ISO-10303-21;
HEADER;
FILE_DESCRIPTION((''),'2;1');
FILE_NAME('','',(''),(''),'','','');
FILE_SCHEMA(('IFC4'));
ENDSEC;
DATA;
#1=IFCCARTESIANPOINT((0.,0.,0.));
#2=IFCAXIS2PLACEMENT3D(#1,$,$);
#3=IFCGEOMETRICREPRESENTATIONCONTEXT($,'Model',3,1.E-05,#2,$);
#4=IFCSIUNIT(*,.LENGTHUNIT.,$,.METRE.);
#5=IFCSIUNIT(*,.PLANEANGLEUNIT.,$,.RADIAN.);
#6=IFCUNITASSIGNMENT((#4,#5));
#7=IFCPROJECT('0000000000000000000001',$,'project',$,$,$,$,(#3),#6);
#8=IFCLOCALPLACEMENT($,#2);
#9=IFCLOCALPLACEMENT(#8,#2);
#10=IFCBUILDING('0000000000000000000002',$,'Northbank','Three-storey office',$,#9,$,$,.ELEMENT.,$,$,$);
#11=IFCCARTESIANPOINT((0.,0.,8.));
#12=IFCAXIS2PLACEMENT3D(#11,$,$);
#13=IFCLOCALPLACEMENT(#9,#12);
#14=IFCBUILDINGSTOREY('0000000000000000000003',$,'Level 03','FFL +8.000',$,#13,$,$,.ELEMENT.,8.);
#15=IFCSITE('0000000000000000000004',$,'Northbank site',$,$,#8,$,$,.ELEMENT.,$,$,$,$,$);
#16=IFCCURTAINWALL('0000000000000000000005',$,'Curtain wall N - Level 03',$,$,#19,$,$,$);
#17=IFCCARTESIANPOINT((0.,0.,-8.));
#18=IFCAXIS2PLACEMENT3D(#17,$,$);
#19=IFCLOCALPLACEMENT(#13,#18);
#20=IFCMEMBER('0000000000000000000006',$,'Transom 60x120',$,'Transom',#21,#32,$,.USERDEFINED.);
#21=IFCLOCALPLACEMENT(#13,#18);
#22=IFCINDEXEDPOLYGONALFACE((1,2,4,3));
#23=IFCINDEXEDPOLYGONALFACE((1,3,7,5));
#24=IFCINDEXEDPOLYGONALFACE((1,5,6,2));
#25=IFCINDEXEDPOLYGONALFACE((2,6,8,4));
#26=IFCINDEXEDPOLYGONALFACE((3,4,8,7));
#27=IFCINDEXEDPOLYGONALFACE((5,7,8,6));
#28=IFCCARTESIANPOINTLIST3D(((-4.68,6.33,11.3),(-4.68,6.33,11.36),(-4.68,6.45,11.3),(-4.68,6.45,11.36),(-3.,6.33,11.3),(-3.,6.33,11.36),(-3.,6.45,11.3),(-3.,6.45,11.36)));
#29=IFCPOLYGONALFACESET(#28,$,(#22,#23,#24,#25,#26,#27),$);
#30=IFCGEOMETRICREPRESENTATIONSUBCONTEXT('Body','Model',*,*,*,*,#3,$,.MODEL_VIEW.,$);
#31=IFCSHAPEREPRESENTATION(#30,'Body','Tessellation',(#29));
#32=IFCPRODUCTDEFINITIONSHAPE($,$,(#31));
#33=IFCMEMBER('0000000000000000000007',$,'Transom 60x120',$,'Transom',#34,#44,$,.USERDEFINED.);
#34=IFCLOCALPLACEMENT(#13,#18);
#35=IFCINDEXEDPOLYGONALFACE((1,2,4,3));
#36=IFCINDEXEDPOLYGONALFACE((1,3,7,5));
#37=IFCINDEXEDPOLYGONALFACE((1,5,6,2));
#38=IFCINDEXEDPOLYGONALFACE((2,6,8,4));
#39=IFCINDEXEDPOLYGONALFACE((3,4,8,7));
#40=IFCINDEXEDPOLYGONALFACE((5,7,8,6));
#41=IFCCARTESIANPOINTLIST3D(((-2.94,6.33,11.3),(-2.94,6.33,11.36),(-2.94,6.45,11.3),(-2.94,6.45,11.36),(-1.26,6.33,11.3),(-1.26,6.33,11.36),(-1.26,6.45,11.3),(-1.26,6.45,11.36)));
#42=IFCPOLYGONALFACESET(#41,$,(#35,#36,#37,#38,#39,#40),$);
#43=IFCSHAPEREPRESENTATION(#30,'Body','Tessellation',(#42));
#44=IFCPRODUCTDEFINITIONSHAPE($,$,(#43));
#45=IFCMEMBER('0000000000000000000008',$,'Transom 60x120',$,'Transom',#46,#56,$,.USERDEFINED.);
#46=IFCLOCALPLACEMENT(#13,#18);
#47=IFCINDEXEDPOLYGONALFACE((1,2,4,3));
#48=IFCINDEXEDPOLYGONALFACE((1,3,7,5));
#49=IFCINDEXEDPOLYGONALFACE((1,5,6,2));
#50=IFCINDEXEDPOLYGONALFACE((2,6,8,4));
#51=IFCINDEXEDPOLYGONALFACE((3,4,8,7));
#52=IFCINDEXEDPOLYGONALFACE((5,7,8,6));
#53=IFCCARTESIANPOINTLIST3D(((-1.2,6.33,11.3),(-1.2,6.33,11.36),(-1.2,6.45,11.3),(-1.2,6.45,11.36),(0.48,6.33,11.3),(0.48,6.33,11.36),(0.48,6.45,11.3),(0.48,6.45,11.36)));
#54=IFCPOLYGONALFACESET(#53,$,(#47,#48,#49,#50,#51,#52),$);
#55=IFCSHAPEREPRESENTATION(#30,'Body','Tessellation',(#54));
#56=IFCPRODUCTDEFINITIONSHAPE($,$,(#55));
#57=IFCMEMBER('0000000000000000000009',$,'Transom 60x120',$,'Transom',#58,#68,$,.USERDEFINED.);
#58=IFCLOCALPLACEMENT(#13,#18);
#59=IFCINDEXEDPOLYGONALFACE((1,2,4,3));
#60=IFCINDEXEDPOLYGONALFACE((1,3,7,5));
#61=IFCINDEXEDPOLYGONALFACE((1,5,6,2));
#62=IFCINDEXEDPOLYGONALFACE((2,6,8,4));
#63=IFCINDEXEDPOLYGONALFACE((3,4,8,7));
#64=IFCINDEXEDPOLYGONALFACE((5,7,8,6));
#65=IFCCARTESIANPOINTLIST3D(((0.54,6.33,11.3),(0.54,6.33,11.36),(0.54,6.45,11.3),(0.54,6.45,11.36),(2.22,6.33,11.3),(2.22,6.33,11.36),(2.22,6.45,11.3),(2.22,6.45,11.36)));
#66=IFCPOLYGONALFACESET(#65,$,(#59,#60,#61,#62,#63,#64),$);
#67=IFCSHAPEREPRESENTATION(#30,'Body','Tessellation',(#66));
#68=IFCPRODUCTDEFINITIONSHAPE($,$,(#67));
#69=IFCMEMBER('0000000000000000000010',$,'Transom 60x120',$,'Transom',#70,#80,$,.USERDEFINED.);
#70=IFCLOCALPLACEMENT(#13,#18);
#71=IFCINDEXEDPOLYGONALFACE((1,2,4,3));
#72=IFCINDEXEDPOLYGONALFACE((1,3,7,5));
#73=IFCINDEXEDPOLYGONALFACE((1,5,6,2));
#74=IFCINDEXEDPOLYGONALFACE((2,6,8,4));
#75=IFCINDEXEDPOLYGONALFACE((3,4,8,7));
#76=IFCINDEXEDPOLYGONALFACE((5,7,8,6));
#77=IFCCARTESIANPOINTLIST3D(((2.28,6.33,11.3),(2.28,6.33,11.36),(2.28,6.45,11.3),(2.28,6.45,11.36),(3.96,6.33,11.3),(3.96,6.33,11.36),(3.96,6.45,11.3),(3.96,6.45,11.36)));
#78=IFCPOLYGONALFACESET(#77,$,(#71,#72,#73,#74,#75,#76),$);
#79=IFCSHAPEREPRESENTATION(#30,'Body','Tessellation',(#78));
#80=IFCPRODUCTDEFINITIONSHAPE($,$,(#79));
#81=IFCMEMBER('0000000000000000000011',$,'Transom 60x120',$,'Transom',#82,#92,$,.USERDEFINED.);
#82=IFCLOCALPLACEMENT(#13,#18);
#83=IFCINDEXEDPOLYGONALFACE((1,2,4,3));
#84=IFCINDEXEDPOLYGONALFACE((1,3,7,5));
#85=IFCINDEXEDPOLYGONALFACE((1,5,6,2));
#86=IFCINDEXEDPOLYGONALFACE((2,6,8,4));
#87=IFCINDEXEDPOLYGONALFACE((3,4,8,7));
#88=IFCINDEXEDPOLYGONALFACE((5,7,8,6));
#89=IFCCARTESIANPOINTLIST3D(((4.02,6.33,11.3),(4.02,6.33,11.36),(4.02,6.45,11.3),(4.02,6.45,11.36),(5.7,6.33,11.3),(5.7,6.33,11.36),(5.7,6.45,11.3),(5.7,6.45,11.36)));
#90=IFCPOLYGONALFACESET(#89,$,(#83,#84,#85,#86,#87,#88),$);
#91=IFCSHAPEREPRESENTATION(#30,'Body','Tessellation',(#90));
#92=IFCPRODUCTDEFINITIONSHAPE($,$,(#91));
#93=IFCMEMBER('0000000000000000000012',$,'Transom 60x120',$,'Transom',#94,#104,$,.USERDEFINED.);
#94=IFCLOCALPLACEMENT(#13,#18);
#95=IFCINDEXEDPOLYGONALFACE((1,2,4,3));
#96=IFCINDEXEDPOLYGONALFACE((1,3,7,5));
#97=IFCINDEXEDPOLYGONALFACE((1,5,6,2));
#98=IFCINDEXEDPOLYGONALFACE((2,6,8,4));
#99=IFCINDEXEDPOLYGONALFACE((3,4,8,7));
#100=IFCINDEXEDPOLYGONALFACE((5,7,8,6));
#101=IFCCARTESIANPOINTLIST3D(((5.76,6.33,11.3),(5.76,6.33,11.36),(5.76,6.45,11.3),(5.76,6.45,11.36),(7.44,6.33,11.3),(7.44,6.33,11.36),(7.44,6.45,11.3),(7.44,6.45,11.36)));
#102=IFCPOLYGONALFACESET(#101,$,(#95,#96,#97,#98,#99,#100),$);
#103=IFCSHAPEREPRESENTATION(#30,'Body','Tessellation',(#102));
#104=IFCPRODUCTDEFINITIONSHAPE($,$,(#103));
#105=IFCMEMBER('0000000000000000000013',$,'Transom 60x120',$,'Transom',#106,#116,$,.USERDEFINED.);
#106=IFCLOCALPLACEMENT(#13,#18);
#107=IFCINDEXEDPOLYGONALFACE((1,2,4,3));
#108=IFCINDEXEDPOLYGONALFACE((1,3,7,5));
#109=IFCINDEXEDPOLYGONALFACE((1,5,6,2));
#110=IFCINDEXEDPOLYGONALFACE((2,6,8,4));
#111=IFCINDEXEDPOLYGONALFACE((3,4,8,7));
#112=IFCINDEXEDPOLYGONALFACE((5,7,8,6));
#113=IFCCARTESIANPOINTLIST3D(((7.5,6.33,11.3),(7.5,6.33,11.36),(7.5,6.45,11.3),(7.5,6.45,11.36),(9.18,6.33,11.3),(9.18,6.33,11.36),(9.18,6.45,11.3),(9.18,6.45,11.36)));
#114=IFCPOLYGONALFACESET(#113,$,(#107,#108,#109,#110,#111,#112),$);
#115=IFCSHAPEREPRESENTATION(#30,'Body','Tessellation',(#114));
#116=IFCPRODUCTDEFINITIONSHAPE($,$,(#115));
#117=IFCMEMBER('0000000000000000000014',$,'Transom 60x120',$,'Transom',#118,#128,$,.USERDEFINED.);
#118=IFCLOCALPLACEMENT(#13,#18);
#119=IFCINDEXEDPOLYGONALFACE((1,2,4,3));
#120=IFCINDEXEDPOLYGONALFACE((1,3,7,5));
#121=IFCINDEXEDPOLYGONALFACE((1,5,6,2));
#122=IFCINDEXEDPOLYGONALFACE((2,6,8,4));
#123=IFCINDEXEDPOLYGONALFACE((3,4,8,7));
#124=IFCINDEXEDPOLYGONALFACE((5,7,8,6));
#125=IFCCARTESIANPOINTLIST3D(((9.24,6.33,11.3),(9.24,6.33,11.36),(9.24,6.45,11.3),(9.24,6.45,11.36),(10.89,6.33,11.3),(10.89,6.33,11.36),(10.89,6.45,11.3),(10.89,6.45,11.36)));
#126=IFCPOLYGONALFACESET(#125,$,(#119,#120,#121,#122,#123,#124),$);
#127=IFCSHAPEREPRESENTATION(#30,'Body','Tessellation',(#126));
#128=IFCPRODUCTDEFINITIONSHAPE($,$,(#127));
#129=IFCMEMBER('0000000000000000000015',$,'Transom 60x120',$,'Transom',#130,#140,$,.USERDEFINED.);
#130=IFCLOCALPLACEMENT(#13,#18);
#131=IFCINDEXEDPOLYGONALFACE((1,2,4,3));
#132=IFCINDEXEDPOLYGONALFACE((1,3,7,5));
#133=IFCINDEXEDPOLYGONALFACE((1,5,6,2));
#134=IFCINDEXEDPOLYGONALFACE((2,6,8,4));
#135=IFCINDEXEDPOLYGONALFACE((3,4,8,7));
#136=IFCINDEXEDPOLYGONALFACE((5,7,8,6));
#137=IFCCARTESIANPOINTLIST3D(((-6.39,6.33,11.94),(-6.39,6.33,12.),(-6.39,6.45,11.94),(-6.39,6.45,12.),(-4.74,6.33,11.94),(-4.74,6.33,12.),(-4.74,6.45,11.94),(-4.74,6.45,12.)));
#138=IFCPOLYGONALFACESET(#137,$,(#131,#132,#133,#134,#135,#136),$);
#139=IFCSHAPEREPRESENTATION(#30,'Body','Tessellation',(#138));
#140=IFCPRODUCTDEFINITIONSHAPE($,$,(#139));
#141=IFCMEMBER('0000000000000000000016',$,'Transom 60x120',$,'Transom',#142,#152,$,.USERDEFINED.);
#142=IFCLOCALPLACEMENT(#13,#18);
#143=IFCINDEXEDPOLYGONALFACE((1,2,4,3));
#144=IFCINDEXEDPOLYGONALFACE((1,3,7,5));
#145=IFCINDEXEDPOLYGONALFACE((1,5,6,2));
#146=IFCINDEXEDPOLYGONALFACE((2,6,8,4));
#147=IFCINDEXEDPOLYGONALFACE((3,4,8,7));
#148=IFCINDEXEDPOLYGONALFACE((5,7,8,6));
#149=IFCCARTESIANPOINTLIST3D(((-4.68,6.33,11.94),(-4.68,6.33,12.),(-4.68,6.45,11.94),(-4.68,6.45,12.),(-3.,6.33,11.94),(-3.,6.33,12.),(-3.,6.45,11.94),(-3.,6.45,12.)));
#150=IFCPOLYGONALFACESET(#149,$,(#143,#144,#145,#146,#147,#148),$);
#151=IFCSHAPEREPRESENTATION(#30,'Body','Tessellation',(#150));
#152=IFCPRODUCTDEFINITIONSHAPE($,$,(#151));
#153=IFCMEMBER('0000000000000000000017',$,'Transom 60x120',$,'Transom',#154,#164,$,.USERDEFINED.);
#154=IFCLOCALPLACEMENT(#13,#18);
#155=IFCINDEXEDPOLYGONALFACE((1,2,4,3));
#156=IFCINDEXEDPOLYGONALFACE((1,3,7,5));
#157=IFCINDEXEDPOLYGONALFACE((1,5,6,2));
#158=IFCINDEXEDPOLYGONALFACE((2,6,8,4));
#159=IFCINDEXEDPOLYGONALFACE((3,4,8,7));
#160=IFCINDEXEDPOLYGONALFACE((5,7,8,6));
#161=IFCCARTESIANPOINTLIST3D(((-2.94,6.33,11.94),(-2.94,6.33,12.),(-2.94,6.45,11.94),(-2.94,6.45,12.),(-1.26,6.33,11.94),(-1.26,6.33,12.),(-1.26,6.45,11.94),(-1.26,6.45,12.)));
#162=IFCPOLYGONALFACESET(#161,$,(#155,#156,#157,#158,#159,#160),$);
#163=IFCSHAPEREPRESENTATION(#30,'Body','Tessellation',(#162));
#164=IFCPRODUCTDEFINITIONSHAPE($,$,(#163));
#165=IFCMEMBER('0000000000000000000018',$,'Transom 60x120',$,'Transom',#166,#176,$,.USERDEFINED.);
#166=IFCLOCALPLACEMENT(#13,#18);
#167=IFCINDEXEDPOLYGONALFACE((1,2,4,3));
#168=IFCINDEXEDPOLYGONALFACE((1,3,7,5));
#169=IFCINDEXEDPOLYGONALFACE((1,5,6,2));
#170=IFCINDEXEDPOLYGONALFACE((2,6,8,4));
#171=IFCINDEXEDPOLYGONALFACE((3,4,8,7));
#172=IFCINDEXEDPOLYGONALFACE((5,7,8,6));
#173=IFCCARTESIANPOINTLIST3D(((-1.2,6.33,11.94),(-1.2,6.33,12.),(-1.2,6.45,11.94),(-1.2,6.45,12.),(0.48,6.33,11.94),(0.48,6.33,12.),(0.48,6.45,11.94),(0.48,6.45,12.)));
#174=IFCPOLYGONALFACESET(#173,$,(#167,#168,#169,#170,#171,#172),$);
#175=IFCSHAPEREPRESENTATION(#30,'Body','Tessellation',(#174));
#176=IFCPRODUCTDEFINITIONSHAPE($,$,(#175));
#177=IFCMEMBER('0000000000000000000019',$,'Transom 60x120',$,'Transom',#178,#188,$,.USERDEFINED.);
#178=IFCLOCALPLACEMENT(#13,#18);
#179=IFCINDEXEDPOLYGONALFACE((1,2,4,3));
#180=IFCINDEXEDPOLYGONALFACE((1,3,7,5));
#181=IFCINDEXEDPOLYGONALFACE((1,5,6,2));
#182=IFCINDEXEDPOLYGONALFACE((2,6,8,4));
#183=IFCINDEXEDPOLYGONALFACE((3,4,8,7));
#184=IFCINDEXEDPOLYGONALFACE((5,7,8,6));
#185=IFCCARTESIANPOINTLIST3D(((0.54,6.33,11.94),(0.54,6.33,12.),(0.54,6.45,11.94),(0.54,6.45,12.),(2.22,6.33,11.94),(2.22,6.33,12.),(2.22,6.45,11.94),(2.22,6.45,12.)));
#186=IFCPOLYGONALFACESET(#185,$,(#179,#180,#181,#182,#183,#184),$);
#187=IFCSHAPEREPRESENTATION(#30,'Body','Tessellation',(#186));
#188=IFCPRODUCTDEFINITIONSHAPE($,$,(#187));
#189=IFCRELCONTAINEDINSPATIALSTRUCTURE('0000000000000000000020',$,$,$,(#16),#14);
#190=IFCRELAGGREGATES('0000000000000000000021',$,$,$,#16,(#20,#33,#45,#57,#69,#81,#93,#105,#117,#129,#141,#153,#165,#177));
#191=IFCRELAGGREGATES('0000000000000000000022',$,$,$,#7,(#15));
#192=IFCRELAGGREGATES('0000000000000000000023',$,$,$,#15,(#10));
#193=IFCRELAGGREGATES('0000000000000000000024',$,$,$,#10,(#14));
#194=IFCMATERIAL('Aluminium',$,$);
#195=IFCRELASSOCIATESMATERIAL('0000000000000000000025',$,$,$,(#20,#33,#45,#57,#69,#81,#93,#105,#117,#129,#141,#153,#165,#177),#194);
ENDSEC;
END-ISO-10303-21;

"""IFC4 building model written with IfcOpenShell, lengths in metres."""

from ifc_helpers import new_model, si_unit, frame, origin, place, context, subcontext, project, spatial, rectangle, extrude, material, element, aggregate, save


model = new_model("IFC4")

# Units and contexts
model_context = context("Model", 3, precision=1e-05, world=origin())
body_context = subcontext(model_context, "Body", "Model", "MODEL_VIEW")
ifc_project = project(units=[si_unit("LENGTHUNIT", "METRE"), si_unit("PLANEANGLEUNIT", "RADIAN")], contexts=[model_context])

# Site, building, storey
site_placement = place(None, origin())
site = spatial("IfcSite", under=ifc_project, at=site_placement, Name="Northbank site", CompositionType="ELEMENT")
building_placement = place(site_placement, origin())
building = spatial("IfcBuilding", under=site, at=building_placement, Name="Northbank", Description="Three-storey office", CompositionType="ELEMENT")
storey_placement = place(building_placement, frame((0.0, 0.0, 8.0)))
storey = spatial("IfcBuildingStorey", under=building, at=storey_placement, Name="Level 03", Description="FFL +8.000", CompositionType="ELEMENT", Elevation=8.0)

# Curtain wall, members
curtain_wall_placement = place(storey_placement, frame((0.0, 0.0, -8.0)))
curtain_wall = element("IfcCurtainWall", 1, at=curtain_wall_placement, inside=storey, Name="Curtain wall N - Level 03")
ifc_material_1 = material(Name="Aluminium")
member_1_placement = place(storey_placement, frame((0.0, 0.0, -8.0)))
member_1 = element("IfcMember", 2, at=member_1_placement, material=ifc_material_1, Name="Transom 60x120", ObjectType="Transom", PredefinedType="USERDEFINED", context=body_context, shape_type="SweptSolid", body=[
    extrude(rectangle(XDim=1.68, YDim=0.12), frame((-3.84, 6.39, 11.3)), (0.0, 0.0, 1.0), 0.06),
])
member_2_placement = place(storey_placement, frame((0.0, 0.0, -8.0)))
member_2 = element("IfcMember", 3, at=member_2_placement, material=ifc_material_1, Name="Transom 60x120", ObjectType="Transom", PredefinedType="USERDEFINED", context=body_context, shape_type="SweptSolid", body=[
    extrude(rectangle(XDim=1.68, YDim=0.12), frame((-2.1, 6.39, 11.3)), (0.0, 0.0, 1.0), 0.06),
])
member_3_placement = place(storey_placement, frame((0.0, 0.0, -8.0)))
member_3 = element("IfcMember", 4, at=member_3_placement, material=ifc_material_1, Name="Transom 60x120", ObjectType="Transom", PredefinedType="USERDEFINED", context=body_context, shape_type="SweptSolid", body=[
    extrude(rectangle(XDim=1.68, YDim=0.12), frame((-0.36, 6.39, 11.3)), (0.0, 0.0, 1.0), 0.06),
])
member_4_placement = place(storey_placement, frame((0.0, 0.0, -8.0)))
member_4 = element("IfcMember", 5, at=member_4_placement, material=ifc_material_1, Name="Transom 60x120", ObjectType="Transom", PredefinedType="USERDEFINED", context=body_context, shape_type="SweptSolid", body=[
    extrude(rectangle(XDim=1.68, YDim=0.12), frame((1.38, 6.39, 11.3)), (0.0, 0.0, 1.0), 0.06),
])
member_5_placement = place(storey_placement, frame((0.0, 0.0, -8.0)))
member_5 = element("IfcMember", 6, at=member_5_placement, material=ifc_material_1, Name="Transom 60x120", ObjectType="Transom", PredefinedType="USERDEFINED", context=body_context, shape_type="SweptSolid", body=[
    extrude(rectangle(XDim=1.68, YDim=0.12), frame((3.12, 6.39, 11.3)), (0.0, 0.0, 1.0), 0.06),
])
member_6_placement = place(storey_placement, frame((0.0, 0.0, -8.0)))
member_6 = element("IfcMember", 7, at=member_6_placement, material=ifc_material_1, Name="Transom 60x120", ObjectType="Transom", PredefinedType="USERDEFINED", context=body_context, shape_type="SweptSolid", body=[
    extrude(rectangle(XDim=1.68, YDim=0.12), frame((4.86, 6.39, 11.3)), (0.0, 0.0, 1.0), 0.06),
])
member_7_placement = place(storey_placement, frame((0.0, 0.0, -8.0)))
member_7 = element("IfcMember", 8, at=member_7_placement, material=ifc_material_1, Name="Transom 60x120", ObjectType="Transom", PredefinedType="USERDEFINED", context=body_context, shape_type="SweptSolid", body=[
    extrude(rectangle(XDim=1.68, YDim=0.12), frame((6.6, 6.39, 11.3)), (0.0, 0.0, 1.0), 0.06),
])
member_8_placement = place(storey_placement, frame((0.0, 0.0, -8.0)))
member_8 = element("IfcMember", 9, at=member_8_placement, material=ifc_material_1, Name="Transom 60x120", ObjectType="Transom", PredefinedType="USERDEFINED", context=body_context, shape_type="SweptSolid", body=[
    extrude(rectangle(XDim=1.68, YDim=0.12), frame((8.34, 6.39, 11.3)), (0.0, 0.0, 1.0), 0.06),
])
member_9_placement = place(storey_placement, frame((0.0, 0.0, -8.0)))
member_9 = element("IfcMember", 10, at=member_9_placement, material=ifc_material_1, Name="Transom 60x120", ObjectType="Transom", PredefinedType="USERDEFINED", context=body_context, shape_type="SweptSolid", body=[
    extrude(rectangle(XDim=1.65, YDim=0.12), frame((10.065, 6.39, 11.3)), (0.0, 0.0, 1.0), 0.06),
])
member_10_placement = place(storey_placement, frame((0.0, 0.0, -8.0)))
member_10 = element("IfcMember", 11, at=member_10_placement, material=ifc_material_1, Name="Transom 60x120", ObjectType="Transom", PredefinedType="USERDEFINED", context=body_context, shape_type="SweptSolid", body=[
    extrude(rectangle(XDim=1.65, YDim=0.12), frame((-5.565, 6.39, 11.94)), (0.0, 0.0, 1.0), 0.06),
])
member_11_placement = place(storey_placement, frame((0.0, 0.0, -8.0)))
member_11 = element("IfcMember", 12, at=member_11_placement, material=ifc_material_1, Name="Transom 60x120", ObjectType="Transom", PredefinedType="USERDEFINED", context=body_context, shape_type="SweptSolid", body=[
    extrude(rectangle(XDim=1.68, YDim=0.12), frame((-3.84, 6.39, 11.94)), (0.0, 0.0, 1.0), 0.06),
])
member_12_placement = place(storey_placement, frame((0.0, 0.0, -8.0)))
member_12 = element("IfcMember", 13, at=member_12_placement, material=ifc_material_1, Name="Transom 60x120", ObjectType="Transom", PredefinedType="USERDEFINED", context=body_context, shape_type="SweptSolid", body=[
    extrude(rectangle(XDim=1.68, YDim=0.12), frame((-2.1, 6.39, 11.94)), (0.0, 0.0, 1.0), 0.06),
])
member_13_placement = place(storey_placement, frame((0.0, 0.0, -8.0)))
member_13 = element("IfcMember", 14, at=member_13_placement, material=ifc_material_1, Name="Transom 60x120", ObjectType="Transom", PredefinedType="USERDEFINED", context=body_context, shape_type="SweptSolid", body=[
    extrude(rectangle(XDim=1.68, YDim=0.12), frame((-0.36, 6.39, 11.94)), (0.0, 0.0, 1.0), 0.06),
])
member_14_placement = place(storey_placement, frame((0.0, 0.0, -8.0)))
member_14 = element("IfcMember", 15, at=member_14_placement, material=ifc_material_1, Name="Transom 60x120", ObjectType="Transom", PredefinedType="USERDEFINED", context=body_context, shape_type="SweptSolid", body=[
    extrude(rectangle(XDim=1.68, YDim=0.12), frame((1.38, 6.39, 11.94)), (0.0, 0.0, 1.0), 0.06),
])
aggregate(curtain_wall, [member_1, member_2, member_3, member_4, member_5, member_6, member_7, member_8, member_9, member_10, member_11, member_12, member_13, member_14])

save(model, "model.ifc")
